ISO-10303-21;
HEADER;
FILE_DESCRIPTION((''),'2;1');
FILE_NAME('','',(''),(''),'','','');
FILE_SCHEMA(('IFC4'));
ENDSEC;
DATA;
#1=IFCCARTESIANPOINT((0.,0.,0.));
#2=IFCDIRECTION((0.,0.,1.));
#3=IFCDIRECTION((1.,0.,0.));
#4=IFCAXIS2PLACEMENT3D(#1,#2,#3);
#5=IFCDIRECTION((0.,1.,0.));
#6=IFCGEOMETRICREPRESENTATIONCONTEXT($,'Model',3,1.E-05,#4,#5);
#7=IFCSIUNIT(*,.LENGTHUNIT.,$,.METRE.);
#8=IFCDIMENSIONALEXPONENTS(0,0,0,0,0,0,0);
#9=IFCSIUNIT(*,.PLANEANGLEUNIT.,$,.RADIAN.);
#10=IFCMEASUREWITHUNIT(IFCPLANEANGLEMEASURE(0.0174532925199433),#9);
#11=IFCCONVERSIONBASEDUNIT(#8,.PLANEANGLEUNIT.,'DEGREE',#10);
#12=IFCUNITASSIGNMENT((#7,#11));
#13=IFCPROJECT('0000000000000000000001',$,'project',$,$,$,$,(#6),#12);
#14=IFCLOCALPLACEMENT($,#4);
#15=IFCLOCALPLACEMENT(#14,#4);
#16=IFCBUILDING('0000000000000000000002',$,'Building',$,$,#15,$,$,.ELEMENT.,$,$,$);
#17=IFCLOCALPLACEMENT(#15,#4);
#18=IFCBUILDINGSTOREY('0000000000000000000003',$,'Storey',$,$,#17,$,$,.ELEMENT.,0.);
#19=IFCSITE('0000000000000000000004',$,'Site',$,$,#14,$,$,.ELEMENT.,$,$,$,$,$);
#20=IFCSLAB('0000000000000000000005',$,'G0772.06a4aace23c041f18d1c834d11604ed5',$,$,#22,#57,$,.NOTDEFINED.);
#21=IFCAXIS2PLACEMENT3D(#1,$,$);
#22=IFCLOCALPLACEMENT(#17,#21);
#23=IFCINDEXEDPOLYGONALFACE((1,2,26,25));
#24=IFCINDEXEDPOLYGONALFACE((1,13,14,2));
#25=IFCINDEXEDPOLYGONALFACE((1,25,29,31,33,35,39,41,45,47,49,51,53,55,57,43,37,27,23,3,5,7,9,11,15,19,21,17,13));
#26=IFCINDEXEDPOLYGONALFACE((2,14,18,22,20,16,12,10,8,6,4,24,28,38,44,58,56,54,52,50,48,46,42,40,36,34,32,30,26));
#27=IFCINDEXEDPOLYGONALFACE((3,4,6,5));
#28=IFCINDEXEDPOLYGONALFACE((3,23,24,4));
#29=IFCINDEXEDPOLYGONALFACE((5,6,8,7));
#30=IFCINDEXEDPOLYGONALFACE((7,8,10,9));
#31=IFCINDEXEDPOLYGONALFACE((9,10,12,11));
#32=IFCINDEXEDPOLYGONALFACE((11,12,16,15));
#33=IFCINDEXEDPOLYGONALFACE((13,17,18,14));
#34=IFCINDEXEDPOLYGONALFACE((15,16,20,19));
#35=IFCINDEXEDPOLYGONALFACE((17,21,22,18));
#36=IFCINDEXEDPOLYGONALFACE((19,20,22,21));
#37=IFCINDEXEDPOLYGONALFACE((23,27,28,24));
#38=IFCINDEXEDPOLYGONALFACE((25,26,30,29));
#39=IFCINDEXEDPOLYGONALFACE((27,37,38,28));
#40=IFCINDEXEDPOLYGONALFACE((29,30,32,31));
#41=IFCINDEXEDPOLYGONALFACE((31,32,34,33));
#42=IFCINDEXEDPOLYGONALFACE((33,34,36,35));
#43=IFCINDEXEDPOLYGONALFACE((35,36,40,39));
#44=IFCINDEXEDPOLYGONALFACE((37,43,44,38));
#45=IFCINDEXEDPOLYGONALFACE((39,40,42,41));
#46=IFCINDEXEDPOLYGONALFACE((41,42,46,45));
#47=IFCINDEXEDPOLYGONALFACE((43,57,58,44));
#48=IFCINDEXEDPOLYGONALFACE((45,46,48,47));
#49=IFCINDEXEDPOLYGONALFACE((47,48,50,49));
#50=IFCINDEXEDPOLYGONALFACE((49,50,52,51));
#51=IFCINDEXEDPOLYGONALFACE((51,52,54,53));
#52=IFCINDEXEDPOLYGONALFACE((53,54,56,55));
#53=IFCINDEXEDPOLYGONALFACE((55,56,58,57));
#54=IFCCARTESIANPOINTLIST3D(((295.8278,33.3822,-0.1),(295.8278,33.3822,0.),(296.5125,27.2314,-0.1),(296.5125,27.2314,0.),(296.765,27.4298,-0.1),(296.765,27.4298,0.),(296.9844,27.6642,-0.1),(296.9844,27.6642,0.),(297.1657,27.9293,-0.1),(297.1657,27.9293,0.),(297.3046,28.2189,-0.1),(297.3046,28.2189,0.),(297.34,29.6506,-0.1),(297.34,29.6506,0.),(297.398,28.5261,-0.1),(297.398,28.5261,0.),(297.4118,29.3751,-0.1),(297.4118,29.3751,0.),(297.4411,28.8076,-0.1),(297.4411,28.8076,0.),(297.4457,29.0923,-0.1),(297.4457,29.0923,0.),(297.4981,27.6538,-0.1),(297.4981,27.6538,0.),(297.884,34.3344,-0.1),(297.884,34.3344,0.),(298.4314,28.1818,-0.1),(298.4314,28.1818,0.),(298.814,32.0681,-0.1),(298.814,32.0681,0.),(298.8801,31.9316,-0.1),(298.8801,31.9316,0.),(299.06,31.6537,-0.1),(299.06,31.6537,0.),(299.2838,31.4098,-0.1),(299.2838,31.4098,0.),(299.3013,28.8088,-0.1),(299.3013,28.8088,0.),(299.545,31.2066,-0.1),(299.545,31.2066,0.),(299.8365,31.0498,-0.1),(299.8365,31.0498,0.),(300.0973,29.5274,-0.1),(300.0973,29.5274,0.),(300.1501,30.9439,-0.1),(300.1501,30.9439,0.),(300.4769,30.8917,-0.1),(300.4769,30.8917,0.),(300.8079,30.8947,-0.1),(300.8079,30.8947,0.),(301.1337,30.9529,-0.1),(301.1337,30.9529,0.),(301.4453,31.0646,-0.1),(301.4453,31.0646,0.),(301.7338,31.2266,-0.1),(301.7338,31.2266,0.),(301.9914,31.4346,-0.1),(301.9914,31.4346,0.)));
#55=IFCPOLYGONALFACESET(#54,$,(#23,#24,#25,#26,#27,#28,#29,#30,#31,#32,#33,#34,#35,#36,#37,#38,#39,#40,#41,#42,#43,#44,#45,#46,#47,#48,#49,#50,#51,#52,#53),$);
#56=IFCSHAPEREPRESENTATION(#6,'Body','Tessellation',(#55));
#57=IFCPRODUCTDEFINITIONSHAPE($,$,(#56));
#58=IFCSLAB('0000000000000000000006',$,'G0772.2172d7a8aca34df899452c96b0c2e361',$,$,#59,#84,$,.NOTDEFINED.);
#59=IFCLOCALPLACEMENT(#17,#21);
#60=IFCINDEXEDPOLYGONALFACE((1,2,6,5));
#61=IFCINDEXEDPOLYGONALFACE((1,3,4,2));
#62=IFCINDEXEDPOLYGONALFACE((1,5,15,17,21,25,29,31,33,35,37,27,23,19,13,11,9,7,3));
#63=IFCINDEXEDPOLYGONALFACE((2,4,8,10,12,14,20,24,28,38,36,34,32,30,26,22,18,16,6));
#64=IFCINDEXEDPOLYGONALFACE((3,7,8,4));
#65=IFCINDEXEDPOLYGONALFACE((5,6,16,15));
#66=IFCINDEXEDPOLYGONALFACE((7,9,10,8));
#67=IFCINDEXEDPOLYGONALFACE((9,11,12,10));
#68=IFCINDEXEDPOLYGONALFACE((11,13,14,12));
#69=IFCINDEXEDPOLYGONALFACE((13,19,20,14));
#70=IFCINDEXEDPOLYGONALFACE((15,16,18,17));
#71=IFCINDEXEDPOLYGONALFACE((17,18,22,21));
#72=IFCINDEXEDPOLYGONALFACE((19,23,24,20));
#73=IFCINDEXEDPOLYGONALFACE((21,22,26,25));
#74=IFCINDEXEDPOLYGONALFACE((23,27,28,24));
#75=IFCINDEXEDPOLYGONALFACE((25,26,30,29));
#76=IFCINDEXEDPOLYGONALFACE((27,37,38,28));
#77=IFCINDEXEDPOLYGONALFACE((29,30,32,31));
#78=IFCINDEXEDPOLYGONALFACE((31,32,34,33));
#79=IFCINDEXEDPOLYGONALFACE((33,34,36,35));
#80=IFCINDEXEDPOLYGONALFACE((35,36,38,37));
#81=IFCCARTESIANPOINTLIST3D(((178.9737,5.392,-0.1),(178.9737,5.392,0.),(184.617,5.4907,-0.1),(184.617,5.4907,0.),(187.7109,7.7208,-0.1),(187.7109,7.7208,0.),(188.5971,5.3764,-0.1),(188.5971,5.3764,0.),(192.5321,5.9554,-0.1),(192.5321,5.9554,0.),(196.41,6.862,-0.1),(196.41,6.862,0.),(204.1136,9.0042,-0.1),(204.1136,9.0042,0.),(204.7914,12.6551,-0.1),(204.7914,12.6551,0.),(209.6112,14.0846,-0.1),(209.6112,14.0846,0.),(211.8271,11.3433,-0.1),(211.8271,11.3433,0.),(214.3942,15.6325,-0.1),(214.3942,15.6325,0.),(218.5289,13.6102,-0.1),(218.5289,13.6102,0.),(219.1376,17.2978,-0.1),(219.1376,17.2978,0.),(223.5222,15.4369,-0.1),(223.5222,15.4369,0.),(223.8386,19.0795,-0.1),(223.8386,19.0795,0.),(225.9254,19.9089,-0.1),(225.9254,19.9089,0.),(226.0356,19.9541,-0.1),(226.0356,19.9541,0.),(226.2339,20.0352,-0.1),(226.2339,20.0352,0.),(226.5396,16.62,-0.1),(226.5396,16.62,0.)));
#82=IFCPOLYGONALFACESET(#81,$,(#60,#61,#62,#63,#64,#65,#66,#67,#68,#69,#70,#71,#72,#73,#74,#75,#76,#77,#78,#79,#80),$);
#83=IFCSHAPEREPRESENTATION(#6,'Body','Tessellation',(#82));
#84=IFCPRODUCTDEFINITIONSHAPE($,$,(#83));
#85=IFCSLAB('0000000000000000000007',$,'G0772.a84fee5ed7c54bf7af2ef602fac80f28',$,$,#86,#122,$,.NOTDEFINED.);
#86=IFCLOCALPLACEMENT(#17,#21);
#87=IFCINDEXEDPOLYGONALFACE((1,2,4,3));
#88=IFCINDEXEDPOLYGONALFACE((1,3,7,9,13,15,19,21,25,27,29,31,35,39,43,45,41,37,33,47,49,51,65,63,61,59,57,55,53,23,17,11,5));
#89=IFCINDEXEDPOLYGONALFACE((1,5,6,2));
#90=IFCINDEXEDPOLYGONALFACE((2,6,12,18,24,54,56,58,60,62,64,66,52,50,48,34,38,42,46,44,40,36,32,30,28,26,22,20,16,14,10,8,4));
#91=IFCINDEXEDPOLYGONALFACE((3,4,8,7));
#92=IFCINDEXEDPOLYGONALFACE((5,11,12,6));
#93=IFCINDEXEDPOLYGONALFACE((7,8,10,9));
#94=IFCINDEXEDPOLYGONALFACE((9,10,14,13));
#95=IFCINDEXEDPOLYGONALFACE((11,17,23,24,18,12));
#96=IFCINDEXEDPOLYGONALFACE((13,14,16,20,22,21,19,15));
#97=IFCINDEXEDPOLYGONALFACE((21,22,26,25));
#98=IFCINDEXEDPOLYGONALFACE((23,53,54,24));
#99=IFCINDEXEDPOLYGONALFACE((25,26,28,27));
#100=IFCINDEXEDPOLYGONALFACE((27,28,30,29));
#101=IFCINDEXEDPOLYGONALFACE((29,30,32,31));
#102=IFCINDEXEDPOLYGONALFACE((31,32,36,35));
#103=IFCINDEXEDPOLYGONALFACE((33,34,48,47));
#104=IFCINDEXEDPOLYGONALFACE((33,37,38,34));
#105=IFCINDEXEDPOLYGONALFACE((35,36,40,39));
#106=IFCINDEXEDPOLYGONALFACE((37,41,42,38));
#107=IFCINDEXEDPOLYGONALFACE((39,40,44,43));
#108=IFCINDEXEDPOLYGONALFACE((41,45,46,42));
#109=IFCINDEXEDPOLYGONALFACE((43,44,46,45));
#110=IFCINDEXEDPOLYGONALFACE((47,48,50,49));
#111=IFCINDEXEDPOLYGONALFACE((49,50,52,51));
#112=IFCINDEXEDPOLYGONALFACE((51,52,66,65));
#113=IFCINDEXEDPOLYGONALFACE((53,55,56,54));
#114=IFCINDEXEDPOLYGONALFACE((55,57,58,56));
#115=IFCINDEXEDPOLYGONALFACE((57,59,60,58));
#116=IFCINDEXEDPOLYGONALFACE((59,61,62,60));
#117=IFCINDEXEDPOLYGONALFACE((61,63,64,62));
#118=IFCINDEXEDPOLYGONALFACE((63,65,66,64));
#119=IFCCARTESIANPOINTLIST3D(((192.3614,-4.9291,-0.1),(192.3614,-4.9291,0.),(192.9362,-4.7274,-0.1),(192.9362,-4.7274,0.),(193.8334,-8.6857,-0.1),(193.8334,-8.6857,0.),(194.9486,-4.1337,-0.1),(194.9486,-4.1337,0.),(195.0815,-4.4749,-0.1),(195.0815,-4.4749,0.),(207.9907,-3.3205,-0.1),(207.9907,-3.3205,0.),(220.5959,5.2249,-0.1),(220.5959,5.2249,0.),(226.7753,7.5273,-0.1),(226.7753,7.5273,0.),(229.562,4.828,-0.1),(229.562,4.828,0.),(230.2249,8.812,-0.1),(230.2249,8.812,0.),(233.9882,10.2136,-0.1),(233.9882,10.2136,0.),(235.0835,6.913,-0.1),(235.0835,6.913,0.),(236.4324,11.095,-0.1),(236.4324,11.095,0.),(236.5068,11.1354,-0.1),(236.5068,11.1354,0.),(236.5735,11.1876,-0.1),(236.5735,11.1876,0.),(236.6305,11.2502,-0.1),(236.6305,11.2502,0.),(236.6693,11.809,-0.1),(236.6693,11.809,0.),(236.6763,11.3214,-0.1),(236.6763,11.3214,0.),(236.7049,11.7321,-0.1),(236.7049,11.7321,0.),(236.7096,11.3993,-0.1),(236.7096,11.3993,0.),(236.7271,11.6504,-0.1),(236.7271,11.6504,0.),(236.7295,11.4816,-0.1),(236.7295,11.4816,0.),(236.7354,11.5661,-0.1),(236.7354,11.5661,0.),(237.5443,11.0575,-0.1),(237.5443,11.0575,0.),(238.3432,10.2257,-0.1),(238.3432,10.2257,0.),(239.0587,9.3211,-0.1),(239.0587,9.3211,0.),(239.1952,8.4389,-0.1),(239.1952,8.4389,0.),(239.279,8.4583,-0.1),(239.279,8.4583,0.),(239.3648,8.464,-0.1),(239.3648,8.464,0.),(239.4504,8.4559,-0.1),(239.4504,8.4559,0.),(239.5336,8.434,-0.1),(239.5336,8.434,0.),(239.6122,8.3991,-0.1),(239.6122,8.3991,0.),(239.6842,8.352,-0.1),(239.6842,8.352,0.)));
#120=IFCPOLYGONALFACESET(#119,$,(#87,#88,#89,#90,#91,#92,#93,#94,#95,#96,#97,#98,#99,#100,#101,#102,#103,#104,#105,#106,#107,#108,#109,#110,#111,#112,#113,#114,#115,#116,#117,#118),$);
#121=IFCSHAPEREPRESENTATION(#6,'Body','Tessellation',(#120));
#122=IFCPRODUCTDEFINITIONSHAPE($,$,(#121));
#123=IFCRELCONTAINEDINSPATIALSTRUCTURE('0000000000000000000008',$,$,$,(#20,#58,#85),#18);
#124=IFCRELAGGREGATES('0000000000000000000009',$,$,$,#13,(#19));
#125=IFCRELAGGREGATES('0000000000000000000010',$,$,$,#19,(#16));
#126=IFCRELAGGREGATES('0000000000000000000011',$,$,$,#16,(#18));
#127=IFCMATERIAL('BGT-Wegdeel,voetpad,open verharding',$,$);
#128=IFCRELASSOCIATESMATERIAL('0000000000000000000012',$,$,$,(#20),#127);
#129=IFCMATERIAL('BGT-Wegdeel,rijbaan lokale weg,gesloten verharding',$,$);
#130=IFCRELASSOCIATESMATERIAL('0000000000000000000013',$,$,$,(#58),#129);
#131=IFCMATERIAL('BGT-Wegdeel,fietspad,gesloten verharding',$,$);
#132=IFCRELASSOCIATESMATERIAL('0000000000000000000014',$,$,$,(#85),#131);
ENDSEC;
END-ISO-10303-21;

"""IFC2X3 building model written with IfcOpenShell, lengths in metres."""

from ifc_helpers import new_model, entity, si_unit, converted_unit, direction, frame, origin_with_axes, place, context, project, spatial, polyline, outline, extrude, material, element, save


model = new_model("IFC2X3")

# Units and contexts
model_context = context("Model", 3, precision=1e-05, world=origin_with_axes(), true_north=direction((0.0, 1.0, 0.0)))
ifc_project = project(units=[si_unit("LENGTHUNIT", "METRE"), converted_unit("PLANEANGLEUNIT", "DEGREE", entity("IfcPlaneAngleMeasure", 0.0174532925199433), si_unit("PLANEANGLEUNIT", "RADIAN"), dimensions=[0, 0, 0, 0, 0, 0, 0])], contexts=[model_context])

# Site, building, storey
site_placement = place(None, origin_with_axes())
site = spatial("IfcSite", under=ifc_project, at=site_placement, Name="Site", CompositionType="ELEMENT")
building_placement = place(site_placement, origin_with_axes())
building = spatial("IfcBuilding", under=site, at=building_placement, Name="Building", CompositionType="ELEMENT")
storey_placement = place(building_placement, origin_with_axes())
storey = spatial("IfcBuildingStorey", under=building, at=storey_placement, Name="Storey", CompositionType="ELEMENT", Elevation=0.0)

# Slabs
ifc_material_1 = material(Name="BGT-Wegdeel,voetpad,open verharding")
ifc_material_2 = material(Name="BGT-Wegdeel,fietspad,gesloten verharding")
slab_1_placement = place(storey_placement, frame((0.0, 0.0, -0.1), z_axis=(0.0, 0.0, 1.0), x_axis=(1.0, 0.0, 0.0)))
element("IfcSlab", 1, at=slab_1_placement, inside=storey, material=ifc_material_1, Name="G0772.06a4aace23c041f18d1c834d11604ed5", PredefinedType="NOTDEFINED", context=model_context, shape_type="SweptSolid", body=[
    extrude(outline(polyline([(298.814, 32.0681), (298.8801, 31.9316), (299.06, 31.6537), (299.2838, 31.4098), (299.545, 31.2066), (299.8365, 31.0498), (300.1501, 30.9439), (300.4769, 30.8917), (300.8079, 30.8947), (301.1337, 30.9529), (301.4453, 31.0646), (301.7338, 31.2266), (301.9914, 31.4346), (300.0973, 29.5274), (299.3013, 28.8088), (298.4314, 28.1818), (297.4981, 27.6538), (296.5125, 27.2314), (296.765, 27.4298), (296.9844, 27.6642), (297.1657, 27.9293), (297.3046, 28.2189), (297.398, 28.5261), (297.4411, 28.8076), (297.4457, 29.0923), (297.4118, 29.3751), (297.34, 29.6506), (295.8278, 33.3822), (297.884, 34.3344), (298.814, 32.0681)])), origin_with_axes(), (0.0, 0.0, 1.0), 0.1),
])
ifc_material_3 = material(Name="BGT-Wegdeel,rijbaan lokale weg,gesloten verharding")
slab_2_placement = place(storey_placement, frame((0.0, 0.0, -0.1), z_axis=(0.0, 0.0, 1.0), x_axis=(1.0, 0.0, 0.0)))
element("IfcSlab", 2, at=slab_2_placement, inside=storey, material=ifc_material_3, Name="G0772.2172d7a8aca34df899452c96b0c2e361", PredefinedType="NOTDEFINED", context=model_context, shape_type="SweptSolid", body=[
    extrude(outline(polyline([(209.6112, 14.0846), (214.3942, 15.6325), (219.1376, 17.2978), (223.8386, 19.0795), (225.9254, 19.9089), (226.0356, 19.9541), (226.2339, 20.0352), (226.5396, 16.62), (223.5222, 15.4369), (218.5289, 13.6102), (211.8271, 11.3433), (204.1136, 9.0042), (196.41, 6.862), (192.5321, 5.9554), (188.5971, 5.3764), (184.617, 5.4907), (178.9737, 5.392), (187.7109, 7.7208), (204.7914, 12.6551), (209.6112, 14.0846)])), origin_with_axes(), (0.0, 0.0, 1.0), 0.1),
])
slab_3_placement = place(storey_placement, frame((0.0, 0.0, -0.1), z_axis=(0.0, 0.0, 1.0), x_axis=(1.0, 0.0, 0.0)))
element("IfcSlab", 3, at=slab_3_placement, inside=storey, material=ifc_material_2, Name="G0772.a84fee5ed7c54bf7af2ef602fac80f28", PredefinedType="NOTDEFINED", context=model_context, shape_type="SweptSolid", body=[
    extrude(outline(polyline([(220.5959, 5.2249), (226.7753, 7.5273), (230.2249, 8.812), (233.9882, 10.2136), (236.4324, 11.095), (236.5068, 11.1354), (236.5735, 11.1876), (236.6305, 11.2502), (236.6763, 11.3214), (236.7096, 11.3993), (236.7295, 11.4816), (236.7354, 11.5661), (236.7271, 11.6504), (236.7049, 11.7321), (236.6693, 11.809), (237.5443, 11.0575), (238.3432, 10.2257), (239.0587, 9.3211), (239.6842, 8.352), (239.6122, 8.3991), (239.5336, 8.434), (239.4504, 8.4559), (239.3648, 8.464), (239.279, 8.4583), (239.1952, 8.4389), (235.0835, 6.913), (229.562, 4.828), (207.9907, -3.3205), (193.8334, -8.6857), (192.3614, -4.9291), (192.9362, -4.7274), (194.9486, -4.1337), (195.0815, -4.4749), (220.5959, 5.2249)])), origin_with_axes(), (0.0, 0.0, 1.0), 0.1),
])

save(model, "model.ifc")
